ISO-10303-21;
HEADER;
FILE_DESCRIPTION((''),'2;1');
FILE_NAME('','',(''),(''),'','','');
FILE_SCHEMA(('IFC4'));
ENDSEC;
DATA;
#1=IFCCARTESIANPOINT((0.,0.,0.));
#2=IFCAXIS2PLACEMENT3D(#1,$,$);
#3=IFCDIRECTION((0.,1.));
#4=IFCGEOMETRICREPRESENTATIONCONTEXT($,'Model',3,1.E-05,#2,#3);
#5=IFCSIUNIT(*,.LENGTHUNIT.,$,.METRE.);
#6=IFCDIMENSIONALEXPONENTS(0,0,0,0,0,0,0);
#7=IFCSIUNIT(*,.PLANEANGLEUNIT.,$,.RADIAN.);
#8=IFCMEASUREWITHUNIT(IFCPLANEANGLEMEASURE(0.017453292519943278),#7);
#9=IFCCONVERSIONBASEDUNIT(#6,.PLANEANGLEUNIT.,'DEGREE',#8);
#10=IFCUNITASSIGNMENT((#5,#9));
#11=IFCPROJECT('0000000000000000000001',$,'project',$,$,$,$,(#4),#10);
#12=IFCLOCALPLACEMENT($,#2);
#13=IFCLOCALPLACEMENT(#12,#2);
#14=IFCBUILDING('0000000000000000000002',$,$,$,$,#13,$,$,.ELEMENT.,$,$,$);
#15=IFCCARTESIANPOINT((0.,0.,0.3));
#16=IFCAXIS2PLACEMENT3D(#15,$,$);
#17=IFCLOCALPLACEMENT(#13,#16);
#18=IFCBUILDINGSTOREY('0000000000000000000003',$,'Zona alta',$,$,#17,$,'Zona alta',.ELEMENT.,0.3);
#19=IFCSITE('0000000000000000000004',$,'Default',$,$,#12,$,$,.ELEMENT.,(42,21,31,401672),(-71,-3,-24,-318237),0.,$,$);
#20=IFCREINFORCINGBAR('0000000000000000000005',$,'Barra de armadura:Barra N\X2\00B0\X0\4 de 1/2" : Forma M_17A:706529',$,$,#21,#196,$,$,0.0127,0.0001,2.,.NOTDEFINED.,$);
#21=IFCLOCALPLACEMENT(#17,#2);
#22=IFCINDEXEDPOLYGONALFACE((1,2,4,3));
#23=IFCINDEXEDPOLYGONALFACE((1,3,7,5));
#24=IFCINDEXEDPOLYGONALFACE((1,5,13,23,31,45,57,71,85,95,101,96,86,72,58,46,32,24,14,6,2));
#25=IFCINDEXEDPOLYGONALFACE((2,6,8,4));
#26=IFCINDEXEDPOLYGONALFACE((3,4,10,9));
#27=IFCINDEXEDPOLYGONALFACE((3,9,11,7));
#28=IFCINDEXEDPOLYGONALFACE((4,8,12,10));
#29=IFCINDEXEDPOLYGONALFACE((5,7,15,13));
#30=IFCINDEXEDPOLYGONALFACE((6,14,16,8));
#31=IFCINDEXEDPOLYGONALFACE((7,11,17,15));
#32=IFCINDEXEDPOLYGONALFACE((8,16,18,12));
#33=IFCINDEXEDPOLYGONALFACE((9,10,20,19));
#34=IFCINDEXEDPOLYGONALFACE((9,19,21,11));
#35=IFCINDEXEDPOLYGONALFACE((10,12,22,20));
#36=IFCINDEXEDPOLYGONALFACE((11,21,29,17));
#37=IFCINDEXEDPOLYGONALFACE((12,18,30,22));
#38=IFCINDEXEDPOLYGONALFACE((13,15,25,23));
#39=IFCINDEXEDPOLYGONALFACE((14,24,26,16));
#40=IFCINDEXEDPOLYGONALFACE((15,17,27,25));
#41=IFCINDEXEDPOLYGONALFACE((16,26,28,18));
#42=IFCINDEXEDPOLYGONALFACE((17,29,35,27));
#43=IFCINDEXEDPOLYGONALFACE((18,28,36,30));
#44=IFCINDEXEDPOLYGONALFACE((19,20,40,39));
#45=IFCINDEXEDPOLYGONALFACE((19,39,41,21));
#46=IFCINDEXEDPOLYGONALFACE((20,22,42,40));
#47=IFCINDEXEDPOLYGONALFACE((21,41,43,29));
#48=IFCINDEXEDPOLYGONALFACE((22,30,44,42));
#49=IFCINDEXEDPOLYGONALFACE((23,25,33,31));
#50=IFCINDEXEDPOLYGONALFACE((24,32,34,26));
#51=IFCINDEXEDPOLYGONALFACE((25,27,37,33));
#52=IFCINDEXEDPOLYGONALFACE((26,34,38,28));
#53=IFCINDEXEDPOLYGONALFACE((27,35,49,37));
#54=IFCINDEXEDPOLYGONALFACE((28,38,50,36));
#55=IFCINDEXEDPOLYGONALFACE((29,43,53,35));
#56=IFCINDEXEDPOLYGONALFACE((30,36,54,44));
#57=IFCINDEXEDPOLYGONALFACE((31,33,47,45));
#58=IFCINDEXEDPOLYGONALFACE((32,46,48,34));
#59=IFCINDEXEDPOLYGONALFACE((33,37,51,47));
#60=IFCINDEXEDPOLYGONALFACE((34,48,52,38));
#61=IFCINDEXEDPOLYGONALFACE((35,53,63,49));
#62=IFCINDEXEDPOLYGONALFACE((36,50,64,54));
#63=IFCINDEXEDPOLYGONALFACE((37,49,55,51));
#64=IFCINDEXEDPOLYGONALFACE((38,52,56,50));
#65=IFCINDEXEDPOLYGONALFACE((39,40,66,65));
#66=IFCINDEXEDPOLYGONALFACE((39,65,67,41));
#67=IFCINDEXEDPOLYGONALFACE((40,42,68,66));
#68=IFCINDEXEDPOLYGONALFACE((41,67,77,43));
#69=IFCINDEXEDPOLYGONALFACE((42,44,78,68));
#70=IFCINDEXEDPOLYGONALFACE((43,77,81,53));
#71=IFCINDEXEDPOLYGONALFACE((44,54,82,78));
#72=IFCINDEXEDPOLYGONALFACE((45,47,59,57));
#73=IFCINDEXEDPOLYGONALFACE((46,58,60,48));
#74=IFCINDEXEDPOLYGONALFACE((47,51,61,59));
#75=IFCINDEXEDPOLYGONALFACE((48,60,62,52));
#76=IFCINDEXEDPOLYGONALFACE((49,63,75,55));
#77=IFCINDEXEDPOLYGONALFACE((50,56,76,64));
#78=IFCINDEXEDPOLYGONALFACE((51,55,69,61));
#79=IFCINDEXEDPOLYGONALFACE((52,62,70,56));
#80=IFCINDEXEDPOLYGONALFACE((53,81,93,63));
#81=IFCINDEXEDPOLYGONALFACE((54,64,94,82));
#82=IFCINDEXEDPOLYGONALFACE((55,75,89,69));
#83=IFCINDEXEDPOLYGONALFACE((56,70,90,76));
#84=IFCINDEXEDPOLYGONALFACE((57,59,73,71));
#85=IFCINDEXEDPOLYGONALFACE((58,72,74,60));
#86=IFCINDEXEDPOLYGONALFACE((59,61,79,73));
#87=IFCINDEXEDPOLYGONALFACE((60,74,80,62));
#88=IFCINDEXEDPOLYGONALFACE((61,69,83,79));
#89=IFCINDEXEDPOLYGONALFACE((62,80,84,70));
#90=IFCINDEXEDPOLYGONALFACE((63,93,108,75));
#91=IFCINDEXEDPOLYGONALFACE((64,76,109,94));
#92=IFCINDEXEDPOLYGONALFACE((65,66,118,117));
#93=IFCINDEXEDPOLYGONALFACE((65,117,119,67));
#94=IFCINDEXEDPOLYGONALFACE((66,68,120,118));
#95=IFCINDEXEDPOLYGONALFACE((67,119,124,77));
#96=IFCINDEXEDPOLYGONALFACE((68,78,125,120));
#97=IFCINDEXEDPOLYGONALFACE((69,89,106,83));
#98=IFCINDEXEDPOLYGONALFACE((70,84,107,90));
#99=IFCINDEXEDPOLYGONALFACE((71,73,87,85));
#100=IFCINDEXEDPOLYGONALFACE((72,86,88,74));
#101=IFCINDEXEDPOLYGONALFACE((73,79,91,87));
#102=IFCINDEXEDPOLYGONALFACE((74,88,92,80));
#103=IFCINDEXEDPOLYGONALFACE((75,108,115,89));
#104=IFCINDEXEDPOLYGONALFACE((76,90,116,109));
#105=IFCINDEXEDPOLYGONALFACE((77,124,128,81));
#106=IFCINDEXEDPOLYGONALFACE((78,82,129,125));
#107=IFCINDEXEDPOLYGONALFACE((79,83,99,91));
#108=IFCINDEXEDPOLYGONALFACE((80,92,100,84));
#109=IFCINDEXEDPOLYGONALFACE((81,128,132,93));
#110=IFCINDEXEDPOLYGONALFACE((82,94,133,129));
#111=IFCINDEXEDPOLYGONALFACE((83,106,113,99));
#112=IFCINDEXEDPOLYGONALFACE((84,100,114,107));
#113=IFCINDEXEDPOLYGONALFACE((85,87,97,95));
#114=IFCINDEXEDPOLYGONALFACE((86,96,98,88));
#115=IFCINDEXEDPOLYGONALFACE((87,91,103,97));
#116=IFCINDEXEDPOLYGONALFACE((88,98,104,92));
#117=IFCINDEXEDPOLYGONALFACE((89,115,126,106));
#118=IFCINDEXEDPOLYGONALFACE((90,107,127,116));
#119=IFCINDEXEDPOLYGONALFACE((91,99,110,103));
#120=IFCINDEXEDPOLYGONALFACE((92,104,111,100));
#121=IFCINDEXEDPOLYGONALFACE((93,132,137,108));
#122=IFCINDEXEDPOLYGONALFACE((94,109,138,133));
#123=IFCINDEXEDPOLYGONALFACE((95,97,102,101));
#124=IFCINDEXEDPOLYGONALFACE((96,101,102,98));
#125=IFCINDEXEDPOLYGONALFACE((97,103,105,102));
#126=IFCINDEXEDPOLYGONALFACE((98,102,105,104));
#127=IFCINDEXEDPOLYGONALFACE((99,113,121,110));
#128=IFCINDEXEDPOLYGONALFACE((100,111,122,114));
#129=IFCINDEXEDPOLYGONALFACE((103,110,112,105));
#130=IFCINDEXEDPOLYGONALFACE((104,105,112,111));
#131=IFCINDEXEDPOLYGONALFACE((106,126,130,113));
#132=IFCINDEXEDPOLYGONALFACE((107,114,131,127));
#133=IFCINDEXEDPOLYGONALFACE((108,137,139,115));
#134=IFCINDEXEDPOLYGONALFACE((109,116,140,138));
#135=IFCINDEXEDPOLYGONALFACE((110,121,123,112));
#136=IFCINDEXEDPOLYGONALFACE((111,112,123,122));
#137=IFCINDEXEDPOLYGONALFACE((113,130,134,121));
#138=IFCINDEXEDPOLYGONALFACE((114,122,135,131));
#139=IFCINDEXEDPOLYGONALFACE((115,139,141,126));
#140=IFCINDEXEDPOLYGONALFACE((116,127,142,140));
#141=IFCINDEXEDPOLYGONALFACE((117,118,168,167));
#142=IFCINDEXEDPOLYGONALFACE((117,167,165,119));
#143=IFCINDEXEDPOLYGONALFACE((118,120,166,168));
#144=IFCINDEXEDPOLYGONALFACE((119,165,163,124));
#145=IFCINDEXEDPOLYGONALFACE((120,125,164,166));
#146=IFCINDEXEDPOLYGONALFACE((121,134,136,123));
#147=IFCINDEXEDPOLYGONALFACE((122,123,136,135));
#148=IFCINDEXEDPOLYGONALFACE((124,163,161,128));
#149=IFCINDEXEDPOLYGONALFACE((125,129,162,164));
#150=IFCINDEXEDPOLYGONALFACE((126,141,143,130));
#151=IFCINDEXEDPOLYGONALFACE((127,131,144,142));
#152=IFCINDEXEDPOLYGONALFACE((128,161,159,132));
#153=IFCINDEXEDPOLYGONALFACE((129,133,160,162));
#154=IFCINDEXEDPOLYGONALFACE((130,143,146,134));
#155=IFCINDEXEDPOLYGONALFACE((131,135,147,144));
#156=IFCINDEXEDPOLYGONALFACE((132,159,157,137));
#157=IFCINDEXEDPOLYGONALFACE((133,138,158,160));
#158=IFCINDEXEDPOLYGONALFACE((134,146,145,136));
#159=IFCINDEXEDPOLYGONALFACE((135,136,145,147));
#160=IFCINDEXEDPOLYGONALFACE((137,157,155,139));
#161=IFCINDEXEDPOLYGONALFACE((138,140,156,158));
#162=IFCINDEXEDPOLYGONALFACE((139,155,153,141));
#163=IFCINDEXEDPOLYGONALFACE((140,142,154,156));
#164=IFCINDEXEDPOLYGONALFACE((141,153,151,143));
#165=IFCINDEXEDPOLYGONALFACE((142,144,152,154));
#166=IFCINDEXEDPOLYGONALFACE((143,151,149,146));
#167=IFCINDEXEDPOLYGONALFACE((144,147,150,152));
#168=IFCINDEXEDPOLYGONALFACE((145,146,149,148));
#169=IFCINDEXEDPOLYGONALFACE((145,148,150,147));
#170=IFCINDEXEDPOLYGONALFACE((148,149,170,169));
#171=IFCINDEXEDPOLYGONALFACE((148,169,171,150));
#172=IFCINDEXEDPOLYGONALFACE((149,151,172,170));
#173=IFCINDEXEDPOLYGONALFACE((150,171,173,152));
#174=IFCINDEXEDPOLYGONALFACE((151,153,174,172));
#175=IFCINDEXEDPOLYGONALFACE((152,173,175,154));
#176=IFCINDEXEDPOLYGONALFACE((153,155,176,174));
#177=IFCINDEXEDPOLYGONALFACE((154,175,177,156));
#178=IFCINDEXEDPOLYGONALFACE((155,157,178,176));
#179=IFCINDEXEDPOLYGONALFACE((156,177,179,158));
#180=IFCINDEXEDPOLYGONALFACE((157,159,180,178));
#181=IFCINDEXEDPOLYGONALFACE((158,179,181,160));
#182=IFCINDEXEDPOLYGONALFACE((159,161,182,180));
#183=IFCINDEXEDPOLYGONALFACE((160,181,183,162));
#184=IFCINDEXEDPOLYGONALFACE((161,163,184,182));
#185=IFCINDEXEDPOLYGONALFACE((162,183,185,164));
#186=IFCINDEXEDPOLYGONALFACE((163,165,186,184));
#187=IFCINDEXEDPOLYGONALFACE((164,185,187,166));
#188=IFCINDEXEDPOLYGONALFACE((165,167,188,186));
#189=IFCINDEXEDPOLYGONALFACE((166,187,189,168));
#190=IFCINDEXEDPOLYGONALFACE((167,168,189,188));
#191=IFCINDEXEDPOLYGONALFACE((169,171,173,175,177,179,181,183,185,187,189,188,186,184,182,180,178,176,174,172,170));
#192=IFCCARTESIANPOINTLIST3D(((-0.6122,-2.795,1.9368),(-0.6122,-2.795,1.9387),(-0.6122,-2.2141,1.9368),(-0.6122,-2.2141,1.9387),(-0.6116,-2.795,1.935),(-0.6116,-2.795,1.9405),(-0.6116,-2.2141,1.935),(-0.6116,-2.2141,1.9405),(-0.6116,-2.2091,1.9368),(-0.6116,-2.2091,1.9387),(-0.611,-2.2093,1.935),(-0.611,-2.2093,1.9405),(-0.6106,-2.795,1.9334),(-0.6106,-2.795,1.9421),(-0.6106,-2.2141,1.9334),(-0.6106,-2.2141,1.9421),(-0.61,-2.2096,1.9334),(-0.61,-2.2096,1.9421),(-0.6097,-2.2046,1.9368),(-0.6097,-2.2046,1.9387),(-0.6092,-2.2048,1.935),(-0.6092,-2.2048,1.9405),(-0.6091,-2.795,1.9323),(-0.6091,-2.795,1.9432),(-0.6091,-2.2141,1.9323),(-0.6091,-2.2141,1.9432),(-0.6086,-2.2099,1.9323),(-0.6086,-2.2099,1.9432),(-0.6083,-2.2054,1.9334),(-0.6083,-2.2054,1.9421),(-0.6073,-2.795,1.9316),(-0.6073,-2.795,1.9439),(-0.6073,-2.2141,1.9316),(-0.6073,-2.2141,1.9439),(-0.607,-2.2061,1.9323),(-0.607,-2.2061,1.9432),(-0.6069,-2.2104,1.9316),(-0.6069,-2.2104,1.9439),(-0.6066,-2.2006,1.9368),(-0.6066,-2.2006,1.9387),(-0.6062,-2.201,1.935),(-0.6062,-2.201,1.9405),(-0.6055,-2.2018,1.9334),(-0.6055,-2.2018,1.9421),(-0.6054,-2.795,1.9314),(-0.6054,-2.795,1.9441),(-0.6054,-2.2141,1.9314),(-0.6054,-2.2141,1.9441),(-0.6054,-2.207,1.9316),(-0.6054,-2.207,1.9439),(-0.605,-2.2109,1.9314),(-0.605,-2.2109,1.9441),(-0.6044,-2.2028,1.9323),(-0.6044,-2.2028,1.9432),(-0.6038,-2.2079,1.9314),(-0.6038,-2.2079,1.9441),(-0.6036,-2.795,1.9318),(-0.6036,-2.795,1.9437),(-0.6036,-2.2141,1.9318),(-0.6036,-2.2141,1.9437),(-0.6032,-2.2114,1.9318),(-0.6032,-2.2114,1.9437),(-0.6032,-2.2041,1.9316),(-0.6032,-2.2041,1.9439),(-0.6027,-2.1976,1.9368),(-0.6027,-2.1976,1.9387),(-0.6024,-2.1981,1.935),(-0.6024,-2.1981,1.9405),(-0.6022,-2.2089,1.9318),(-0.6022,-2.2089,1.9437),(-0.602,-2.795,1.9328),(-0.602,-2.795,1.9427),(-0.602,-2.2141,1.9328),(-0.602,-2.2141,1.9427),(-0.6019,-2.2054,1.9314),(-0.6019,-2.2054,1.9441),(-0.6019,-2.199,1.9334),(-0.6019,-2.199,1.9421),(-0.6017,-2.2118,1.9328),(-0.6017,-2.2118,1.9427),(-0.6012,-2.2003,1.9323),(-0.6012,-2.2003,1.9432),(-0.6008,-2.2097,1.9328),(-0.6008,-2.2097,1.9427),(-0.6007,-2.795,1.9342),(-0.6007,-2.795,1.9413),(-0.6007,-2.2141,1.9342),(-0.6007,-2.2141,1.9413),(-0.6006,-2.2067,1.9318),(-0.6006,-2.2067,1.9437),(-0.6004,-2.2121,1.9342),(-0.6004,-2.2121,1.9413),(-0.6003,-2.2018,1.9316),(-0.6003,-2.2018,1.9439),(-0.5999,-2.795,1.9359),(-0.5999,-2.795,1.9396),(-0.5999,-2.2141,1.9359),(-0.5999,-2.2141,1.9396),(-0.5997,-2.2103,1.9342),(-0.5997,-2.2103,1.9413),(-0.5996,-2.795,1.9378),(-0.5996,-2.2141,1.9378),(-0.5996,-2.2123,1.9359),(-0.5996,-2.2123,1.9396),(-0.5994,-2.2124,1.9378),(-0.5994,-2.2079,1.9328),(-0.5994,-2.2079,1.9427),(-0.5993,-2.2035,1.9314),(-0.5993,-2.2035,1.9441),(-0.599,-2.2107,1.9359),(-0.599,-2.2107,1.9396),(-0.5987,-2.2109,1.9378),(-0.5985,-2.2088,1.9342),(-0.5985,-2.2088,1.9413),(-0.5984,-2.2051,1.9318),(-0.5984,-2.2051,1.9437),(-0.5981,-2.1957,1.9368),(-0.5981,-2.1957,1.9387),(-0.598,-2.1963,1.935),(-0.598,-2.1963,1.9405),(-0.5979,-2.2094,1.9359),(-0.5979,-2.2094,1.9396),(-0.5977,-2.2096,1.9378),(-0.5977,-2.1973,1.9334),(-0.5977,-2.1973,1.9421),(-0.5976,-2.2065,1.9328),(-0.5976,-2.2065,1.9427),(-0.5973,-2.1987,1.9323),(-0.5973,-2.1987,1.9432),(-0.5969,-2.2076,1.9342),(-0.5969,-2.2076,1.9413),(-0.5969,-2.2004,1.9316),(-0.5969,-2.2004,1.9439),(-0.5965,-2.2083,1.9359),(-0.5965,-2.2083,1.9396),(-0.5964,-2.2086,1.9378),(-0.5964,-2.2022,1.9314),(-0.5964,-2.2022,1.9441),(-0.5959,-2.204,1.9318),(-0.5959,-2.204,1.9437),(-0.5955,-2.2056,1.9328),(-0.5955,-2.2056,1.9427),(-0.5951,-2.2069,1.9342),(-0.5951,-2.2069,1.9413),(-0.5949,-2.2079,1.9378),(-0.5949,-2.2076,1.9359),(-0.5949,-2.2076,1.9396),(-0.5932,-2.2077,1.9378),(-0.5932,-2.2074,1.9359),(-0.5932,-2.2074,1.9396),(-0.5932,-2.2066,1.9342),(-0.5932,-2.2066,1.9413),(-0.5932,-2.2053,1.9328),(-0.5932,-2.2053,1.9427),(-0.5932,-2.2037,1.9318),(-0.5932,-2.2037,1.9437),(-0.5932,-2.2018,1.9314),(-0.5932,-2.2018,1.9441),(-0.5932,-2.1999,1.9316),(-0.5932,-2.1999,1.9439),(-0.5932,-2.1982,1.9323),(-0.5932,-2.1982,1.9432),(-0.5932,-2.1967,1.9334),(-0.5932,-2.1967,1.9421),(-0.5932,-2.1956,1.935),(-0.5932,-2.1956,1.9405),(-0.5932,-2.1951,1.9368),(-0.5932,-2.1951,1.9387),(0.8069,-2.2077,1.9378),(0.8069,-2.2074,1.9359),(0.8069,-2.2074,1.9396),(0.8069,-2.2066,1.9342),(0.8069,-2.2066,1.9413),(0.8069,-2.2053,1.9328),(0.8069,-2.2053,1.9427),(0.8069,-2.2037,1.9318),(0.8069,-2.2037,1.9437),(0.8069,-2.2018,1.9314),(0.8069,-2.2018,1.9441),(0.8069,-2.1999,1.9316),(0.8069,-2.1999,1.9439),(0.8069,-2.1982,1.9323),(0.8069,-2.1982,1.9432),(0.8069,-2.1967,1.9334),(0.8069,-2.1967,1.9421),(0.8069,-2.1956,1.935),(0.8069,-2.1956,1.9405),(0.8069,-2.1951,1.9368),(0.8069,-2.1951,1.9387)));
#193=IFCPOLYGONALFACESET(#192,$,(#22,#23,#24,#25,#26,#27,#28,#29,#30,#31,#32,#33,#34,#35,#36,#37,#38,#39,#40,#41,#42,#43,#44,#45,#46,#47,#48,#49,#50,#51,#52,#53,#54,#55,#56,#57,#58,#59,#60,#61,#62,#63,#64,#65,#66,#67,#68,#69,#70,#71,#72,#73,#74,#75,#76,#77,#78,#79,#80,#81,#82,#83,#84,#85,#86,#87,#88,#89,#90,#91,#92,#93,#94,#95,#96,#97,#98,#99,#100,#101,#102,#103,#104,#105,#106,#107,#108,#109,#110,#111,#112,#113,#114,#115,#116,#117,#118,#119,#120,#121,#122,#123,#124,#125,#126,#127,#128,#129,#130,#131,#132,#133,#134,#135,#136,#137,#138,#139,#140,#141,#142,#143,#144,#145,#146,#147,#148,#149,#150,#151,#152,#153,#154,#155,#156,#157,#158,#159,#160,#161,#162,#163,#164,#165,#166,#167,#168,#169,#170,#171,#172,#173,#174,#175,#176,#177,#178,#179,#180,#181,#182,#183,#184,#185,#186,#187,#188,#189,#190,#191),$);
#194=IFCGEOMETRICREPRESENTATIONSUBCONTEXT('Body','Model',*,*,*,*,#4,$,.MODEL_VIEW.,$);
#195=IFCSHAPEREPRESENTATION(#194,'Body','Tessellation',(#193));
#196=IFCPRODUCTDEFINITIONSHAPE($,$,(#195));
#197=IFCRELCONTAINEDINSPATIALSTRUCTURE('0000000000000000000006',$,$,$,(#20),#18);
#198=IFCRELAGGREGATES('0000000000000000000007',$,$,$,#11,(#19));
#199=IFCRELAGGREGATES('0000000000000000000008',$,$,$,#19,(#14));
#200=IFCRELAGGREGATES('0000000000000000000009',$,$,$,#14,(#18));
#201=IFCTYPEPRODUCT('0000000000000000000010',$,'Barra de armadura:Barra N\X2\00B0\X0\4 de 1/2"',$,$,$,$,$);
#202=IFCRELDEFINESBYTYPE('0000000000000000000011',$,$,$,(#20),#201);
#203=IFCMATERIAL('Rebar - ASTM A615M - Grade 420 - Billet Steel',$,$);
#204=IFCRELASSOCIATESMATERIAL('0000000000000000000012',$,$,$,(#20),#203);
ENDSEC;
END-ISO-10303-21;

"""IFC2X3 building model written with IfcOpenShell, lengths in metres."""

from ifc_helpers import new_model, entity, si_unit, converted_unit, direction, frame, origin, place, context, subcontext, project, spatial, material, type_object, element, save


model = new_model("IFC2X3")

# Units and contexts
model_context = context("Model", 3, precision=1e-05, world=origin(), true_north=direction((0.0, 1.0)))
body_context = subcontext(model_context, "Body", "Model", "MODEL_VIEW")
ifc_project = project(units=[si_unit("LENGTHUNIT", "METRE"), converted_unit("PLANEANGLEUNIT", "DEGREE", entity("IfcPlaneAngleMeasure", 0.017453292519943278), si_unit("PLANEANGLEUNIT", "RADIAN"), dimensions=[0, 0, 0, 0, 0, 0, 0])], contexts=[model_context])

# Site, building, storey
site_placement = place(None, origin())
site = spatial("IfcSite", under=ifc_project, at=site_placement, Name="Default", CompositionType="ELEMENT", RefLatitude=(42, 21, 31, 401672), RefLongitude=(-71, -3, -24, -318237), RefElevation=0.0)
building_placement = place(site_placement, origin())
building = spatial("IfcBuilding", under=site, at=building_placement, CompositionType="ELEMENT")
storey_placement = place(building_placement, frame((0.0, 0.0, 0.3)))
storey = spatial("IfcBuildingStorey", under=building, at=storey_placement, Name="Zona alta", LongName="Zona alta", CompositionType="ELEMENT", Elevation=0.3)

# Reinforcing bar
ifc_material = material(Name="Rebar - ASTM A615M - Grade 420 - Billet Steel")
type_product_1 = type_object("IfcTypeProduct", Name="Barra de armadura:Barra N°4 de 1/2\"")
reinforcing_bar_1_placement = place(storey_placement, origin())
element("IfcReinforcingBar", 1, at=reinforcing_bar_1_placement, inside=storey, type_object=type_product_1, material=ifc_material, Name="Barra de armadura:Barra N°4 de 1/2\" : Forma M_17A:706529", BarLength=2.0, BarRole="NOTDEFINED", CrossSectionArea=0.0001, NominalDiameter=0.0127, context=body_context, shape_type="AdvancedSweptSolid", body=[
    entity("IfcSweptDiskSolid", entity("IfcCompositeCurve", [entity("IfcCompositeCurveSegment", "CONTINUOUS", True, entity("IfcPolyline", [entity("IfcCartesianPoint", [0.8069, -2.2014, 1.9378]), entity("IfcCartesianPoint", [-0.5932, -2.2014, 1.9378])])), entity("IfcCompositeCurveSegment", "CONTINUOUS", True, entity("IfcTrimmedCurve", entity("IfcCircle", entity("IfcAxis2Placement3D", entity("IfcCartesianPoint", [-0.5932, -2.2141, 1.9378]), entity("IfcDirection", [0.0, 0.0, 1.0]), entity("IfcDirection", [-1.0, 0.0, 0.0])), 0.0127), [entity("IfcParameterValue", 270.0)], [entity("IfcParameterValue", 360.0)], True, "PARAMETER")), entity("IfcCompositeCurveSegment", "CONTINUOUS", True, entity("IfcPolyline", [entity("IfcCartesianPoint", [-0.6059, -2.2141, 1.9378]), entity("IfcCartesianPoint", [-0.6059, -2.795, 1.9378])]))], False), 0.0063, None, 0.0, 92.0),
])

save(model, "model.ifc")
